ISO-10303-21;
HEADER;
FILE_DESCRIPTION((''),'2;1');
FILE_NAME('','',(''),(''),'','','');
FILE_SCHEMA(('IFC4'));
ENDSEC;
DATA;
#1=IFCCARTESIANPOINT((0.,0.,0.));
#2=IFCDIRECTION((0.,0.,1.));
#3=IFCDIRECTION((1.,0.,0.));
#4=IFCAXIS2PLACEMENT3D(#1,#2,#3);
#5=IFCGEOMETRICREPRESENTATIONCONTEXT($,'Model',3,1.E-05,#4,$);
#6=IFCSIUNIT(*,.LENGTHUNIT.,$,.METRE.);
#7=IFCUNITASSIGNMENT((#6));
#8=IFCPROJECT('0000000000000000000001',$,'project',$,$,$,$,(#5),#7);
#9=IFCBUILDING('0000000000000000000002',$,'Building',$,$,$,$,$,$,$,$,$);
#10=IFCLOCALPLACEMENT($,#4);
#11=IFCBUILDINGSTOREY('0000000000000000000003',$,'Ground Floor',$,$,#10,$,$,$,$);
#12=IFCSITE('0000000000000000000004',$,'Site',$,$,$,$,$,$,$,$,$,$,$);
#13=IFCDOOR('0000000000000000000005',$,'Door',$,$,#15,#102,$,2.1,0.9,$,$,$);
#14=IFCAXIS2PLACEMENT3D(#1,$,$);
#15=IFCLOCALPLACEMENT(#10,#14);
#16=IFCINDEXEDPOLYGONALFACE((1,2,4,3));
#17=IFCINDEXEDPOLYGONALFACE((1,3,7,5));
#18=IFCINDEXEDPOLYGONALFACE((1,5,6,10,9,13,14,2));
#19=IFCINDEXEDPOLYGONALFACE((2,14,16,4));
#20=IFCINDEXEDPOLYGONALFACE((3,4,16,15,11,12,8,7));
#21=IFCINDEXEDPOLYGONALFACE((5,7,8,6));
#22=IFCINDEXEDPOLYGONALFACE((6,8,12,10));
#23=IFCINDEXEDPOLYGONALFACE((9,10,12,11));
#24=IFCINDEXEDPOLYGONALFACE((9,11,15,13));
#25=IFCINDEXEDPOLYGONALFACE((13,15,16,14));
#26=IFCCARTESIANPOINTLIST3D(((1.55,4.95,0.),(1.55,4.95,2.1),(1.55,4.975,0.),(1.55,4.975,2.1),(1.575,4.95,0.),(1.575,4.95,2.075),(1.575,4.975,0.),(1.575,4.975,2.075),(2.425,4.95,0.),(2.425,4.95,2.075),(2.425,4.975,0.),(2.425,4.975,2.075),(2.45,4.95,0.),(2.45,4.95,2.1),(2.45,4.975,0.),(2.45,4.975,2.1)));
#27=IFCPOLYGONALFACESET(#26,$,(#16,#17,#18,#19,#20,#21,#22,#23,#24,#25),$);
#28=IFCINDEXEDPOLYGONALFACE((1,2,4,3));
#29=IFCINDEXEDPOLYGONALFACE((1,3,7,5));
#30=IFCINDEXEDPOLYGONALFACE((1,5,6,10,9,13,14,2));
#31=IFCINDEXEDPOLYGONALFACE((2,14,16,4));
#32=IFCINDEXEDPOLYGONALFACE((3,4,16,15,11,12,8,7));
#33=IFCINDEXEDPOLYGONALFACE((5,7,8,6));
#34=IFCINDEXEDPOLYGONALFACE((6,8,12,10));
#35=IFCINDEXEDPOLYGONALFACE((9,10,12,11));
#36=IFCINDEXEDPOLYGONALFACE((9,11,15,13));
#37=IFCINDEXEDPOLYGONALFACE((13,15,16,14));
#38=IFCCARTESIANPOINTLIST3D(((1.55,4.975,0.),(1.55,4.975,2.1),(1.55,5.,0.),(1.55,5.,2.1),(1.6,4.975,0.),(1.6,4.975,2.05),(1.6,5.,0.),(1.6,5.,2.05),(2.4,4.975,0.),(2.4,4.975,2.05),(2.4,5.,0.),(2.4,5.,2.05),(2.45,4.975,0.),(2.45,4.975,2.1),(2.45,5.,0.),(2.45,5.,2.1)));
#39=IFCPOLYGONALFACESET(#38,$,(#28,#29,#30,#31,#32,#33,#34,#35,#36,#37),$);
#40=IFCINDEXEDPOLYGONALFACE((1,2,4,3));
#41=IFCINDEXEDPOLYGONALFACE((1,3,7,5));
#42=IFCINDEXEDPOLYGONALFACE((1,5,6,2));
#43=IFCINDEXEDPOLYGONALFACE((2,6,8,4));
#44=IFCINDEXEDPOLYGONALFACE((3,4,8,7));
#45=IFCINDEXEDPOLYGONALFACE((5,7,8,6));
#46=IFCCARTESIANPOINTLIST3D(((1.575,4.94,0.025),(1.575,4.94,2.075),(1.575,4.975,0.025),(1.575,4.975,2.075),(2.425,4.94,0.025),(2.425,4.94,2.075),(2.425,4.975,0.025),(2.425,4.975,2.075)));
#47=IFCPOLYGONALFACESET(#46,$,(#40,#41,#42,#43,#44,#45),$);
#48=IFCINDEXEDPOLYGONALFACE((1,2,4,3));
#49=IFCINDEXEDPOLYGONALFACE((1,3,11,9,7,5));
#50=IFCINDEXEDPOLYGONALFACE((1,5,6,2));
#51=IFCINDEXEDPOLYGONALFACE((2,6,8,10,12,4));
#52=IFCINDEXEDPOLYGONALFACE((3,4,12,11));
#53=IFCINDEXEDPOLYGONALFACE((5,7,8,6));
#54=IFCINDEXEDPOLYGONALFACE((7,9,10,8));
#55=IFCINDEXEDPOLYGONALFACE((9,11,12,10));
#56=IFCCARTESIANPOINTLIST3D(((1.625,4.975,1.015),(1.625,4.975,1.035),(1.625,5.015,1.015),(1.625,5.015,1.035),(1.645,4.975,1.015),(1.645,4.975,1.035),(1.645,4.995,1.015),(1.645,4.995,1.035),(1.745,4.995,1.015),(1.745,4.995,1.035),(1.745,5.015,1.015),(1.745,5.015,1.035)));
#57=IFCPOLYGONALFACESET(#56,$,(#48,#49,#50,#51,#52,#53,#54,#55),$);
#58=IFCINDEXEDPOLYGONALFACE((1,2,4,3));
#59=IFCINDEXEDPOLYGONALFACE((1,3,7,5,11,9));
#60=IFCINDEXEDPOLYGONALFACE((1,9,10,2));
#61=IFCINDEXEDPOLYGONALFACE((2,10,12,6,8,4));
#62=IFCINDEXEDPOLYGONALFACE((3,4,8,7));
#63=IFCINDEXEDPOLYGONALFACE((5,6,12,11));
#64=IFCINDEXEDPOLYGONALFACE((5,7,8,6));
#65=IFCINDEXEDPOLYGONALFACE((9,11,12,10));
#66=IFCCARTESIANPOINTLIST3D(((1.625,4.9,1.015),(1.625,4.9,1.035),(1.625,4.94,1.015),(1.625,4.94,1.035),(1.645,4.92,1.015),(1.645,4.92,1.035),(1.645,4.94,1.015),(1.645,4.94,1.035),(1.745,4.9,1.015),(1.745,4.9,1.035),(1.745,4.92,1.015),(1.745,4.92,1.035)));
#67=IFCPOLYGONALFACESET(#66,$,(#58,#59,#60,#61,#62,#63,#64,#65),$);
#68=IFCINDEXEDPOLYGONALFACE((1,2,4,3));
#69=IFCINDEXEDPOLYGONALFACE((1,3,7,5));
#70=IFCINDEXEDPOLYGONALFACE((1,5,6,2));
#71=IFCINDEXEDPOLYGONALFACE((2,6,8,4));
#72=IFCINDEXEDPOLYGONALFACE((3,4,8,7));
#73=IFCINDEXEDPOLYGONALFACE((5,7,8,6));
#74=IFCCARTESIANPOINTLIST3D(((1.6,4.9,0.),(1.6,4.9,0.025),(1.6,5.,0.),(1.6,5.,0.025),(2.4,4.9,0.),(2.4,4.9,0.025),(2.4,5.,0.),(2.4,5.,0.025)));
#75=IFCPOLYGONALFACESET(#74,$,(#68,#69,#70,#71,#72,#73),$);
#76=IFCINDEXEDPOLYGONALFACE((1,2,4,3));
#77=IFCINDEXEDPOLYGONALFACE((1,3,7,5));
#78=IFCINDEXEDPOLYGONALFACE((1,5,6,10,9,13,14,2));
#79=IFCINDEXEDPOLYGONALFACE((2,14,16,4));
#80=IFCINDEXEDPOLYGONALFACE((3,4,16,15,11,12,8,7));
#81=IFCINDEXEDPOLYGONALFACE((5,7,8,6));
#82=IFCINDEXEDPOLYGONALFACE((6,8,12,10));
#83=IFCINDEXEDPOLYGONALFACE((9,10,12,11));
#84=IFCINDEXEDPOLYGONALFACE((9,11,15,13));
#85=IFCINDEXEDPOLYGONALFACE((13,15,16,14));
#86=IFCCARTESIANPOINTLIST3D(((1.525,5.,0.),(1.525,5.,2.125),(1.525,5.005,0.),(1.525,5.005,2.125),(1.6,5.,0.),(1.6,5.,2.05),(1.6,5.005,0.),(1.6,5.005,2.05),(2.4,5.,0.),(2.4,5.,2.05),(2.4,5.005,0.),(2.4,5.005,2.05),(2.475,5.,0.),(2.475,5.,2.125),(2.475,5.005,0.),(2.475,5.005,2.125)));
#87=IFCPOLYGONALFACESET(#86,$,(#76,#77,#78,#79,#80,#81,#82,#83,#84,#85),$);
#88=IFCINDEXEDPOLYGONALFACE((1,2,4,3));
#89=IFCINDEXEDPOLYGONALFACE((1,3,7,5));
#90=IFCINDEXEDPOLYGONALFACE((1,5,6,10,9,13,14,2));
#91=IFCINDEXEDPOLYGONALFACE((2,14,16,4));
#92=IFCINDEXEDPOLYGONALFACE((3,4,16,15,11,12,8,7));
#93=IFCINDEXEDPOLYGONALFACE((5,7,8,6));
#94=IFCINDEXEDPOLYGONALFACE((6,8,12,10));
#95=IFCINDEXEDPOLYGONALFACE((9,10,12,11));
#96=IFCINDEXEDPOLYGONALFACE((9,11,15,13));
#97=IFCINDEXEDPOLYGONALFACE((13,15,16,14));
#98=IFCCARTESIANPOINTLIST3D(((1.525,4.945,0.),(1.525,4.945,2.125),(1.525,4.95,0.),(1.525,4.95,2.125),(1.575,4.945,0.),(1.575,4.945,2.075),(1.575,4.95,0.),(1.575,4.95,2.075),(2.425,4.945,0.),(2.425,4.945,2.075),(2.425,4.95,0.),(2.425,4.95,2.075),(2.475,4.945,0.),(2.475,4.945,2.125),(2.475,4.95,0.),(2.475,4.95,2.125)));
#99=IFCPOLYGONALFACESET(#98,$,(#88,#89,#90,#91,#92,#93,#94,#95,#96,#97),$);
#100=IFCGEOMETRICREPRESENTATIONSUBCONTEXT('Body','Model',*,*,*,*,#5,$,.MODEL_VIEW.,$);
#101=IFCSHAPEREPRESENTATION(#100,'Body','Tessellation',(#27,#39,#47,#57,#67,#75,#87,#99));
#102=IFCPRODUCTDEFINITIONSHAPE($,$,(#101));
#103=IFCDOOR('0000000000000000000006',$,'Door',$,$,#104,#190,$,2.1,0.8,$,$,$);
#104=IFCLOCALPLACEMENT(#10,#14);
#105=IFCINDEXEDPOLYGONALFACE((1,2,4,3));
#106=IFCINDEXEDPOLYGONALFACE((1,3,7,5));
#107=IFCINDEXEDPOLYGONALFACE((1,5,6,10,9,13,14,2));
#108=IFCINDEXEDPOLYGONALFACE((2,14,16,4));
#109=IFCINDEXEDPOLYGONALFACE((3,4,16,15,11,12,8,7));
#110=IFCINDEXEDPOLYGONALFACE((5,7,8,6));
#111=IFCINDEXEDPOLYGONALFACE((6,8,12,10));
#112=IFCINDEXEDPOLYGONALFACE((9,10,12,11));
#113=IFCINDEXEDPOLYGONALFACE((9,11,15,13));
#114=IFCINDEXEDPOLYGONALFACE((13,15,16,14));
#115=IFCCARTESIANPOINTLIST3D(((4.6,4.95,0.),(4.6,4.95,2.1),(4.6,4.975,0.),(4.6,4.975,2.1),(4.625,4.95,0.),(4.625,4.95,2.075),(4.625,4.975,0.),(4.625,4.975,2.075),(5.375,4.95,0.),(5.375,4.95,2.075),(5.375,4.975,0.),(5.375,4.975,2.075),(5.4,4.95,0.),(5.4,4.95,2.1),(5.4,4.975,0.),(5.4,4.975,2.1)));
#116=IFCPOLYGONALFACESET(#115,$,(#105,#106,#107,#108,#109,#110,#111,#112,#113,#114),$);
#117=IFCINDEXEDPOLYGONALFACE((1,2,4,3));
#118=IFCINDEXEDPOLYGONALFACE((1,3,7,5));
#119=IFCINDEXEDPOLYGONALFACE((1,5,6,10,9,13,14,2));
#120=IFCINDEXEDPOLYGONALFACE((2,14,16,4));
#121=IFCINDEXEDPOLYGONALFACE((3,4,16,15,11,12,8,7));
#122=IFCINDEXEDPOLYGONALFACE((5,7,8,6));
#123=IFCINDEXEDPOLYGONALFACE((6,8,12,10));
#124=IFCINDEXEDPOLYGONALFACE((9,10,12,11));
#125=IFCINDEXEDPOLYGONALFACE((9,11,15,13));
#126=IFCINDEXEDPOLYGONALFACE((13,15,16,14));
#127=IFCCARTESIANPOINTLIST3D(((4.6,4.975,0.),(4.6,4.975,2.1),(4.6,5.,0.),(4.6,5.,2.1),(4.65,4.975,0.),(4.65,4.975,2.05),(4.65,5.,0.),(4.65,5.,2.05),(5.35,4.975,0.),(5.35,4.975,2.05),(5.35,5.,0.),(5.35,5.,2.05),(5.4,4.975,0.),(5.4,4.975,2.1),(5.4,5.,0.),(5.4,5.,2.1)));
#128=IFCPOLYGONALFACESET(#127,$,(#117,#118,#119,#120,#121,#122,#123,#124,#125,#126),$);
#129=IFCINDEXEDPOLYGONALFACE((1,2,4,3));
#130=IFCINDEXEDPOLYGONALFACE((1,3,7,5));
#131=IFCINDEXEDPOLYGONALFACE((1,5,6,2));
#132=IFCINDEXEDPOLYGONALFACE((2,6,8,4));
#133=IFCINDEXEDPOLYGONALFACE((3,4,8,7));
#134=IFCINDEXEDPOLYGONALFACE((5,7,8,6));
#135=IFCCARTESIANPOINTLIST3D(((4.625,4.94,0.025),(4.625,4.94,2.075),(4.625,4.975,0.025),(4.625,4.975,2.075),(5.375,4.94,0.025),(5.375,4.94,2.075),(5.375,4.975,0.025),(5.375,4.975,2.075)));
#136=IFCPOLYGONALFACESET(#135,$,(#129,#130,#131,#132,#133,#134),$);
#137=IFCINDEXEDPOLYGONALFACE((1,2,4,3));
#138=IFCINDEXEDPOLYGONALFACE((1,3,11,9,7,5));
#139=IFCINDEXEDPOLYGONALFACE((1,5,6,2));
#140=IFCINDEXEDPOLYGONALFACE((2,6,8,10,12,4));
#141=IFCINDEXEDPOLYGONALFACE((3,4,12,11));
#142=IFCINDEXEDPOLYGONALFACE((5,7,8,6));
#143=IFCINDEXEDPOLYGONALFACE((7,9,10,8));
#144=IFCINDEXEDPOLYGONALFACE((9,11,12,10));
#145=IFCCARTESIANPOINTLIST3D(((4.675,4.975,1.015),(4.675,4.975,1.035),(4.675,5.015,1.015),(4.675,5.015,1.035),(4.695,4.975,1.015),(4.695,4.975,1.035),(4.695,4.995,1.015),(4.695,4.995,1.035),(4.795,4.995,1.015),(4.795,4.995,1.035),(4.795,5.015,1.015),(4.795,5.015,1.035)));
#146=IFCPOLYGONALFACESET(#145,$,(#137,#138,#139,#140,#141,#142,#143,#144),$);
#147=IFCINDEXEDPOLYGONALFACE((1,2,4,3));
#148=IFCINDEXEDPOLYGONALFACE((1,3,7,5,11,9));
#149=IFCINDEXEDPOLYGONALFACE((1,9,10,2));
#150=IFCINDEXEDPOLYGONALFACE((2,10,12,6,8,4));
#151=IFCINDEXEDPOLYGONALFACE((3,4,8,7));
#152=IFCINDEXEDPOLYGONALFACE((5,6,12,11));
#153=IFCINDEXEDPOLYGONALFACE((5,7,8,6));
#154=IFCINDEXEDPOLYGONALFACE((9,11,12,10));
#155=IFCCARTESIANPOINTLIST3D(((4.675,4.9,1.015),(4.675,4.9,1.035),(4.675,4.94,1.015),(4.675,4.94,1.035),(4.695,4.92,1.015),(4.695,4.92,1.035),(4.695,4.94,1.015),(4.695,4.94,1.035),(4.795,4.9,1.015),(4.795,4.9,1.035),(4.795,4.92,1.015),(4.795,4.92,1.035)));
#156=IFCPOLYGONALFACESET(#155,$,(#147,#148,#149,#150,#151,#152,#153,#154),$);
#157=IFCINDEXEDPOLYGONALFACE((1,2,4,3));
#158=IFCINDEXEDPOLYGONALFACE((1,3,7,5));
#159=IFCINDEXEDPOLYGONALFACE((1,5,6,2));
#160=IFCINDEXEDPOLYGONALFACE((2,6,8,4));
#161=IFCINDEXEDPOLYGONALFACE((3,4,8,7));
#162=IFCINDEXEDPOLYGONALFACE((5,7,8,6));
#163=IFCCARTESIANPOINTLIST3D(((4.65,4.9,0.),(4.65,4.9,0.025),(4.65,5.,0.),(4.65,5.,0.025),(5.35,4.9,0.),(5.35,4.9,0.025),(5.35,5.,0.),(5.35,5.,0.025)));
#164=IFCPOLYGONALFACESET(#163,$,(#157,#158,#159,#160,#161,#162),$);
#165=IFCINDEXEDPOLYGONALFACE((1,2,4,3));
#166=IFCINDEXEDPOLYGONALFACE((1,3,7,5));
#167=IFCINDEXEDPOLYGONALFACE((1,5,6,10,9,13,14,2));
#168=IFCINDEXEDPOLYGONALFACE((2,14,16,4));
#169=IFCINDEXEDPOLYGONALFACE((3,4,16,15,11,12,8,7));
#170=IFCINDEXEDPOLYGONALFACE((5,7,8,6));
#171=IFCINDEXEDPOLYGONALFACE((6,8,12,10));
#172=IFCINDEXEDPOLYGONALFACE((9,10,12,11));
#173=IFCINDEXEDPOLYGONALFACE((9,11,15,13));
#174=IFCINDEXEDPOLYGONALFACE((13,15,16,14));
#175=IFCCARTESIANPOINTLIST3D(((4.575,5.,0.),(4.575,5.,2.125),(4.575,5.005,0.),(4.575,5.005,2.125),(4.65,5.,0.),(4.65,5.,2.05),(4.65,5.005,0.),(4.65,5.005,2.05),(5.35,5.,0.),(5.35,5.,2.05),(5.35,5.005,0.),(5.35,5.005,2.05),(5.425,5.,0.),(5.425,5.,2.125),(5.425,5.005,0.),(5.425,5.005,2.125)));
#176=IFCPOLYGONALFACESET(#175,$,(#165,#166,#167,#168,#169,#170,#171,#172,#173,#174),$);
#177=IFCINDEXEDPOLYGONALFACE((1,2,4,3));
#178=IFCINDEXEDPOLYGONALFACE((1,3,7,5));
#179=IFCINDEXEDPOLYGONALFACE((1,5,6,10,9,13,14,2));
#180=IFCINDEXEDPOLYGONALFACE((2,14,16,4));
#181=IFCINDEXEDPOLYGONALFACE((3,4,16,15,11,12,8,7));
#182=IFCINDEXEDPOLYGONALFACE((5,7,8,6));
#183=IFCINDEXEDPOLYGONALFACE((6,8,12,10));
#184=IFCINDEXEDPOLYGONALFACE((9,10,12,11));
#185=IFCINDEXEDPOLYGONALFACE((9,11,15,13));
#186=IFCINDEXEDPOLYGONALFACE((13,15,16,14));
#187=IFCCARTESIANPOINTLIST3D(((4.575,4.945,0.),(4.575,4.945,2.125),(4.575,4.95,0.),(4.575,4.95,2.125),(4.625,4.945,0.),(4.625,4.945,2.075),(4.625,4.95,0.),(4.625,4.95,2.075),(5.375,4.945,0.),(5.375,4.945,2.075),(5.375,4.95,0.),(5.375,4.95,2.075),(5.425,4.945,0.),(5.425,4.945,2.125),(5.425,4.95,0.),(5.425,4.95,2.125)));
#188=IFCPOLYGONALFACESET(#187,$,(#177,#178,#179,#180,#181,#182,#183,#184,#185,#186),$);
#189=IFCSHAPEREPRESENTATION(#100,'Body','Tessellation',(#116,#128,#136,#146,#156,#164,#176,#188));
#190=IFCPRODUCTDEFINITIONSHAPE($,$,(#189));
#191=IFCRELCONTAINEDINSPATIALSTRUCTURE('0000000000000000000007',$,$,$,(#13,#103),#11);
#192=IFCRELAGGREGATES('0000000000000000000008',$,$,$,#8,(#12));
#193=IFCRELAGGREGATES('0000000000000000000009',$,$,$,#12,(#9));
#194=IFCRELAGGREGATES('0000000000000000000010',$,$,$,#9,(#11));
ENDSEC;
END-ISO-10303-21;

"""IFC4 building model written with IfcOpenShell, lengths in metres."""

from ifc_helpers import new_model, si_unit, frame, origin_with_axes, place, context, subcontext, project, spatial, line, indexed_curve, outline, extrude, element, save


model = new_model("IFC4")

# Units and contexts
model_context = context("Model", 3, precision=1e-05, world=origin_with_axes())
body_context = subcontext(model_context, "Body", "Model", "MODEL_VIEW")
ifc_project = project(units=[si_unit("LENGTHUNIT", "METRE")], contexts=[model_context])

# Site, building, storey
site = spatial("IfcSite", under=ifc_project, Name="Site")
building = spatial("IfcBuilding", under=site, Name="Building")
storey_placement = place(None, origin_with_axes())
storey = spatial("IfcBuildingStorey", under=building, at=storey_placement, Name="Ground Floor")

# Doors
door_1_placement = place(storey_placement, frame((2.45, 5.0, 0.0), z_axis=(0.0, 0.0, 1.0), x_axis=(-1.0, 0.0, 0.0)))
element("IfcDoor", 1, at=door_1_placement, inside=storey, Name="Door", OverallHeight=2.1, OverallWidth=0.9, context=body_context, shape_type="SweptSolid", body=[
    extrude(outline(indexed_curve([(0.0, 0.0), (0.0, 2.1), (0.9, 2.1), (0.9, 0.0), (0.875, 0.0), (0.875, 2.075), (0.025, 2.075), (0.025, 0.0)], segments=[line(1, 2, 3, 4, 5, 6, 7, 8, 1)])), frame((0.0, 0.025, 0.0), z_axis=(0.0, -1.0, 0.0), x_axis=(1.0, 0.0, 0.0)), (0.0, 0.0, -1.0), 0.025),
    extrude(outline(indexed_curve([(0.0, 0.0), (0.0, 2.1), (0.9, 2.1), (0.9, 0.0), (0.85, 0.0), (0.85, 2.05), (0.05, 2.05), (0.05, 0.0)], segments=[line(1, 2, 3, 4, 5, 6, 7, 8, 1)])), frame((0.0, 0.0, 0.0), z_axis=(0.0, -1.0, 0.0), x_axis=(1.0, 0.0, 0.0)), (0.0, 0.0, -1.0), 0.025),
    extrude(outline(indexed_curve([(0.0, 0.0), (0.85, 0.0), (0.85, 0.035), (0.0, 0.035)], segments=[line(1, 2, 3, 4, 1)])), frame((0.025, 0.025, 0.025), z_axis=(0.0, 0.0, 1.0), x_axis=(1.0, 0.0, 0.0)), (0.0, 0.0, 1.0), 2.05),
    extrude(outline(indexed_curve([(0.0, 0.0), (0.0, -0.04), (-0.12, -0.04), (-0.12, -0.02), (-0.02, -0.02), (-0.02, 0.0)], segments=[line(1, 2, 3, 4, 5, 6, 1)])), frame((0.825, 0.025, 1.015), z_axis=(0.0, 0.0, 1.0), x_axis=(1.0, 0.0, 0.0)), (0.0, 0.0, 1.0), 0.02),
    extrude(outline(indexed_curve([(0.0, 0.0), (0.0, 0.04), (-0.12, 0.04), (-0.12, 0.02), (-0.02, 0.02), (-0.02, 0.0)], segments=[line(1, 2, 3, 4, 5, 6, 1)])), frame((0.825, 0.06, 1.015), z_axis=(0.0, 0.0, 1.0), x_axis=(1.0, 0.0, 0.0)), (0.0, 0.0, 1.0), 0.02),
    extrude(outline(indexed_curve([(0.0, 0.0), (0.8, 0.0), (0.8, 0.1), (0.0, 0.1)], segments=[line(1, 2, 3, 4, 1)])), frame((0.05, 0.0, 0.0), z_axis=(0.0, 0.0, 1.0), x_axis=(1.0, 0.0, 0.0)), (0.0, 0.0, 1.0), 0.025),
    extrude(outline(indexed_curve([(0.0, 0.0), (0.0, 2.125), (0.95, 2.125), (0.95, 0.0), (0.875, 0.0), (0.875, 2.05), (0.075, 2.05), (0.075, 0.0)], segments=[line(1, 2, 3, 4, 5, 6, 7, 8, 1)])), frame((-0.025, -0.005, 0.0), z_axis=(0.0, -1.0, 0.0), x_axis=(1.0, 0.0, 0.0)), (0.0, 0.0, -1.0), 0.005),
    extrude(outline(indexed_curve([(0.0, 0.0), (0.0, 2.125), (0.95, 2.125), (0.95, 0.0), (0.9, 0.0), (0.9, 2.075), (0.05, 2.075), (0.05, 0.0)], segments=[line(1, 2, 3, 4, 5, 6, 7, 8, 1)])), frame((-0.025, 0.05, 0.0), z_axis=(0.0, -1.0, 0.0), x_axis=(1.0, 0.0, 0.0)), (0.0, 0.0, -1.0), 0.005),
])
door_2_placement = place(storey_placement, frame((5.4, 5.0, 0.0), z_axis=(0.0, 0.0, 1.0), x_axis=(-1.0, 0.0, 0.0)))
element("IfcDoor", 2, at=door_2_placement, inside=storey, Name="Door", OverallHeight=2.1, OverallWidth=0.8, context=body_context, shape_type="SweptSolid", body=[
    extrude(outline(indexed_curve([(0.0, 0.0), (0.0, 2.1), (0.8, 2.1), (0.8, 0.0), (0.775, 0.0), (0.775, 2.075), (0.025, 2.075), (0.025, 0.0)], segments=[line(1, 2, 3, 4, 5, 6, 7, 8, 1)])), frame((0.0, 0.025, 0.0), z_axis=(0.0, -1.0, 0.0), x_axis=(1.0, 0.0, 0.0)), (0.0, 0.0, -1.0), 0.025),
    extrude(outline(indexed_curve([(0.0, 0.0), (0.0, 2.1), (0.8, 2.1), (0.8, 0.0), (0.75, 0.0), (0.75, 2.05), (0.05, 2.05), (0.05, 0.0)], segments=[line(1, 2, 3, 4, 5, 6, 7, 8, 1)])), frame((0.0, 0.0, 0.0), z_axis=(0.0, -1.0, 0.0), x_axis=(1.0, 0.0, 0.0)), (0.0, 0.0, -1.0), 0.025),
    extrude(outline(indexed_curve([(0.0, 0.0), (0.75, 0.0), (0.75, 0.035), (0.0, 0.035)], segments=[line(1, 2, 3, 4, 1)])), frame((0.025, 0.025, 0.025), z_axis=(0.0, 0.0, 1.0), x_axis=(1.0, 0.0, 0.0)), (0.0, 0.0, 1.0), 2.05),
    extrude(outline(indexed_curve([(0.0, 0.0), (0.0, -0.04), (-0.12, -0.04), (-0.12, -0.02), (-0.02, -0.02), (-0.02, 0.0)], segments=[line(1, 2, 3, 4, 5, 6, 1)])), frame((0.725, 0.025, 1.015), z_axis=(0.0, 0.0, 1.0), x_axis=(1.0, 0.0, 0.0)), (0.0, 0.0, 1.0), 0.02),
    extrude(outline(indexed_curve([(0.0, 0.0), (0.0, 0.04), (-0.12, 0.04), (-0.12, 0.02), (-0.02, 0.02), (-0.02, 0.0)], segments=[line(1, 2, 3, 4, 5, 6, 1)])), frame((0.725, 0.06, 1.015), z_axis=(0.0, 0.0, 1.0), x_axis=(1.0, 0.0, 0.0)), (0.0, 0.0, 1.0), 0.02),
    extrude(outline(indexed_curve([(0.0, 0.0), (0.7, 0.0), (0.7, 0.1), (0.0, 0.1)], segments=[line(1, 2, 3, 4, 1)])), frame((0.05, 0.0, 0.0), z_axis=(0.0, 0.0, 1.0), x_axis=(1.0, 0.0, 0.0)), (0.0, 0.0, 1.0), 0.025),
    extrude(outline(indexed_curve([(0.0, 0.0), (0.0, 2.125), (0.85, 2.125), (0.85, 0.0), (0.775, 0.0), (0.775, 2.05), (0.075, 2.05), (0.075, 0.0)], segments=[line(1, 2, 3, 4, 5, 6, 7, 8, 1)])), frame((-0.025, -0.005, 0.0), z_axis=(0.0, -1.0, 0.0), x_axis=(1.0, 0.0, 0.0)), (0.0, 0.0, -1.0), 0.005),
    extrude(outline(indexed_curve([(0.0, 0.0), (0.0, 2.125), (0.85, 2.125), (0.85, 0.0), (0.8, 0.0), (0.8, 2.075), (0.05, 2.075), (0.05, 0.0)], segments=[line(1, 2, 3, 4, 5, 6, 7, 8, 1)])), frame((-0.025, 0.05, 0.0), z_axis=(0.0, -1.0, 0.0), x_axis=(1.0, 0.0, 0.0)), (0.0, 0.0, -1.0), 0.005),
])

save(model, "model.ifc")
